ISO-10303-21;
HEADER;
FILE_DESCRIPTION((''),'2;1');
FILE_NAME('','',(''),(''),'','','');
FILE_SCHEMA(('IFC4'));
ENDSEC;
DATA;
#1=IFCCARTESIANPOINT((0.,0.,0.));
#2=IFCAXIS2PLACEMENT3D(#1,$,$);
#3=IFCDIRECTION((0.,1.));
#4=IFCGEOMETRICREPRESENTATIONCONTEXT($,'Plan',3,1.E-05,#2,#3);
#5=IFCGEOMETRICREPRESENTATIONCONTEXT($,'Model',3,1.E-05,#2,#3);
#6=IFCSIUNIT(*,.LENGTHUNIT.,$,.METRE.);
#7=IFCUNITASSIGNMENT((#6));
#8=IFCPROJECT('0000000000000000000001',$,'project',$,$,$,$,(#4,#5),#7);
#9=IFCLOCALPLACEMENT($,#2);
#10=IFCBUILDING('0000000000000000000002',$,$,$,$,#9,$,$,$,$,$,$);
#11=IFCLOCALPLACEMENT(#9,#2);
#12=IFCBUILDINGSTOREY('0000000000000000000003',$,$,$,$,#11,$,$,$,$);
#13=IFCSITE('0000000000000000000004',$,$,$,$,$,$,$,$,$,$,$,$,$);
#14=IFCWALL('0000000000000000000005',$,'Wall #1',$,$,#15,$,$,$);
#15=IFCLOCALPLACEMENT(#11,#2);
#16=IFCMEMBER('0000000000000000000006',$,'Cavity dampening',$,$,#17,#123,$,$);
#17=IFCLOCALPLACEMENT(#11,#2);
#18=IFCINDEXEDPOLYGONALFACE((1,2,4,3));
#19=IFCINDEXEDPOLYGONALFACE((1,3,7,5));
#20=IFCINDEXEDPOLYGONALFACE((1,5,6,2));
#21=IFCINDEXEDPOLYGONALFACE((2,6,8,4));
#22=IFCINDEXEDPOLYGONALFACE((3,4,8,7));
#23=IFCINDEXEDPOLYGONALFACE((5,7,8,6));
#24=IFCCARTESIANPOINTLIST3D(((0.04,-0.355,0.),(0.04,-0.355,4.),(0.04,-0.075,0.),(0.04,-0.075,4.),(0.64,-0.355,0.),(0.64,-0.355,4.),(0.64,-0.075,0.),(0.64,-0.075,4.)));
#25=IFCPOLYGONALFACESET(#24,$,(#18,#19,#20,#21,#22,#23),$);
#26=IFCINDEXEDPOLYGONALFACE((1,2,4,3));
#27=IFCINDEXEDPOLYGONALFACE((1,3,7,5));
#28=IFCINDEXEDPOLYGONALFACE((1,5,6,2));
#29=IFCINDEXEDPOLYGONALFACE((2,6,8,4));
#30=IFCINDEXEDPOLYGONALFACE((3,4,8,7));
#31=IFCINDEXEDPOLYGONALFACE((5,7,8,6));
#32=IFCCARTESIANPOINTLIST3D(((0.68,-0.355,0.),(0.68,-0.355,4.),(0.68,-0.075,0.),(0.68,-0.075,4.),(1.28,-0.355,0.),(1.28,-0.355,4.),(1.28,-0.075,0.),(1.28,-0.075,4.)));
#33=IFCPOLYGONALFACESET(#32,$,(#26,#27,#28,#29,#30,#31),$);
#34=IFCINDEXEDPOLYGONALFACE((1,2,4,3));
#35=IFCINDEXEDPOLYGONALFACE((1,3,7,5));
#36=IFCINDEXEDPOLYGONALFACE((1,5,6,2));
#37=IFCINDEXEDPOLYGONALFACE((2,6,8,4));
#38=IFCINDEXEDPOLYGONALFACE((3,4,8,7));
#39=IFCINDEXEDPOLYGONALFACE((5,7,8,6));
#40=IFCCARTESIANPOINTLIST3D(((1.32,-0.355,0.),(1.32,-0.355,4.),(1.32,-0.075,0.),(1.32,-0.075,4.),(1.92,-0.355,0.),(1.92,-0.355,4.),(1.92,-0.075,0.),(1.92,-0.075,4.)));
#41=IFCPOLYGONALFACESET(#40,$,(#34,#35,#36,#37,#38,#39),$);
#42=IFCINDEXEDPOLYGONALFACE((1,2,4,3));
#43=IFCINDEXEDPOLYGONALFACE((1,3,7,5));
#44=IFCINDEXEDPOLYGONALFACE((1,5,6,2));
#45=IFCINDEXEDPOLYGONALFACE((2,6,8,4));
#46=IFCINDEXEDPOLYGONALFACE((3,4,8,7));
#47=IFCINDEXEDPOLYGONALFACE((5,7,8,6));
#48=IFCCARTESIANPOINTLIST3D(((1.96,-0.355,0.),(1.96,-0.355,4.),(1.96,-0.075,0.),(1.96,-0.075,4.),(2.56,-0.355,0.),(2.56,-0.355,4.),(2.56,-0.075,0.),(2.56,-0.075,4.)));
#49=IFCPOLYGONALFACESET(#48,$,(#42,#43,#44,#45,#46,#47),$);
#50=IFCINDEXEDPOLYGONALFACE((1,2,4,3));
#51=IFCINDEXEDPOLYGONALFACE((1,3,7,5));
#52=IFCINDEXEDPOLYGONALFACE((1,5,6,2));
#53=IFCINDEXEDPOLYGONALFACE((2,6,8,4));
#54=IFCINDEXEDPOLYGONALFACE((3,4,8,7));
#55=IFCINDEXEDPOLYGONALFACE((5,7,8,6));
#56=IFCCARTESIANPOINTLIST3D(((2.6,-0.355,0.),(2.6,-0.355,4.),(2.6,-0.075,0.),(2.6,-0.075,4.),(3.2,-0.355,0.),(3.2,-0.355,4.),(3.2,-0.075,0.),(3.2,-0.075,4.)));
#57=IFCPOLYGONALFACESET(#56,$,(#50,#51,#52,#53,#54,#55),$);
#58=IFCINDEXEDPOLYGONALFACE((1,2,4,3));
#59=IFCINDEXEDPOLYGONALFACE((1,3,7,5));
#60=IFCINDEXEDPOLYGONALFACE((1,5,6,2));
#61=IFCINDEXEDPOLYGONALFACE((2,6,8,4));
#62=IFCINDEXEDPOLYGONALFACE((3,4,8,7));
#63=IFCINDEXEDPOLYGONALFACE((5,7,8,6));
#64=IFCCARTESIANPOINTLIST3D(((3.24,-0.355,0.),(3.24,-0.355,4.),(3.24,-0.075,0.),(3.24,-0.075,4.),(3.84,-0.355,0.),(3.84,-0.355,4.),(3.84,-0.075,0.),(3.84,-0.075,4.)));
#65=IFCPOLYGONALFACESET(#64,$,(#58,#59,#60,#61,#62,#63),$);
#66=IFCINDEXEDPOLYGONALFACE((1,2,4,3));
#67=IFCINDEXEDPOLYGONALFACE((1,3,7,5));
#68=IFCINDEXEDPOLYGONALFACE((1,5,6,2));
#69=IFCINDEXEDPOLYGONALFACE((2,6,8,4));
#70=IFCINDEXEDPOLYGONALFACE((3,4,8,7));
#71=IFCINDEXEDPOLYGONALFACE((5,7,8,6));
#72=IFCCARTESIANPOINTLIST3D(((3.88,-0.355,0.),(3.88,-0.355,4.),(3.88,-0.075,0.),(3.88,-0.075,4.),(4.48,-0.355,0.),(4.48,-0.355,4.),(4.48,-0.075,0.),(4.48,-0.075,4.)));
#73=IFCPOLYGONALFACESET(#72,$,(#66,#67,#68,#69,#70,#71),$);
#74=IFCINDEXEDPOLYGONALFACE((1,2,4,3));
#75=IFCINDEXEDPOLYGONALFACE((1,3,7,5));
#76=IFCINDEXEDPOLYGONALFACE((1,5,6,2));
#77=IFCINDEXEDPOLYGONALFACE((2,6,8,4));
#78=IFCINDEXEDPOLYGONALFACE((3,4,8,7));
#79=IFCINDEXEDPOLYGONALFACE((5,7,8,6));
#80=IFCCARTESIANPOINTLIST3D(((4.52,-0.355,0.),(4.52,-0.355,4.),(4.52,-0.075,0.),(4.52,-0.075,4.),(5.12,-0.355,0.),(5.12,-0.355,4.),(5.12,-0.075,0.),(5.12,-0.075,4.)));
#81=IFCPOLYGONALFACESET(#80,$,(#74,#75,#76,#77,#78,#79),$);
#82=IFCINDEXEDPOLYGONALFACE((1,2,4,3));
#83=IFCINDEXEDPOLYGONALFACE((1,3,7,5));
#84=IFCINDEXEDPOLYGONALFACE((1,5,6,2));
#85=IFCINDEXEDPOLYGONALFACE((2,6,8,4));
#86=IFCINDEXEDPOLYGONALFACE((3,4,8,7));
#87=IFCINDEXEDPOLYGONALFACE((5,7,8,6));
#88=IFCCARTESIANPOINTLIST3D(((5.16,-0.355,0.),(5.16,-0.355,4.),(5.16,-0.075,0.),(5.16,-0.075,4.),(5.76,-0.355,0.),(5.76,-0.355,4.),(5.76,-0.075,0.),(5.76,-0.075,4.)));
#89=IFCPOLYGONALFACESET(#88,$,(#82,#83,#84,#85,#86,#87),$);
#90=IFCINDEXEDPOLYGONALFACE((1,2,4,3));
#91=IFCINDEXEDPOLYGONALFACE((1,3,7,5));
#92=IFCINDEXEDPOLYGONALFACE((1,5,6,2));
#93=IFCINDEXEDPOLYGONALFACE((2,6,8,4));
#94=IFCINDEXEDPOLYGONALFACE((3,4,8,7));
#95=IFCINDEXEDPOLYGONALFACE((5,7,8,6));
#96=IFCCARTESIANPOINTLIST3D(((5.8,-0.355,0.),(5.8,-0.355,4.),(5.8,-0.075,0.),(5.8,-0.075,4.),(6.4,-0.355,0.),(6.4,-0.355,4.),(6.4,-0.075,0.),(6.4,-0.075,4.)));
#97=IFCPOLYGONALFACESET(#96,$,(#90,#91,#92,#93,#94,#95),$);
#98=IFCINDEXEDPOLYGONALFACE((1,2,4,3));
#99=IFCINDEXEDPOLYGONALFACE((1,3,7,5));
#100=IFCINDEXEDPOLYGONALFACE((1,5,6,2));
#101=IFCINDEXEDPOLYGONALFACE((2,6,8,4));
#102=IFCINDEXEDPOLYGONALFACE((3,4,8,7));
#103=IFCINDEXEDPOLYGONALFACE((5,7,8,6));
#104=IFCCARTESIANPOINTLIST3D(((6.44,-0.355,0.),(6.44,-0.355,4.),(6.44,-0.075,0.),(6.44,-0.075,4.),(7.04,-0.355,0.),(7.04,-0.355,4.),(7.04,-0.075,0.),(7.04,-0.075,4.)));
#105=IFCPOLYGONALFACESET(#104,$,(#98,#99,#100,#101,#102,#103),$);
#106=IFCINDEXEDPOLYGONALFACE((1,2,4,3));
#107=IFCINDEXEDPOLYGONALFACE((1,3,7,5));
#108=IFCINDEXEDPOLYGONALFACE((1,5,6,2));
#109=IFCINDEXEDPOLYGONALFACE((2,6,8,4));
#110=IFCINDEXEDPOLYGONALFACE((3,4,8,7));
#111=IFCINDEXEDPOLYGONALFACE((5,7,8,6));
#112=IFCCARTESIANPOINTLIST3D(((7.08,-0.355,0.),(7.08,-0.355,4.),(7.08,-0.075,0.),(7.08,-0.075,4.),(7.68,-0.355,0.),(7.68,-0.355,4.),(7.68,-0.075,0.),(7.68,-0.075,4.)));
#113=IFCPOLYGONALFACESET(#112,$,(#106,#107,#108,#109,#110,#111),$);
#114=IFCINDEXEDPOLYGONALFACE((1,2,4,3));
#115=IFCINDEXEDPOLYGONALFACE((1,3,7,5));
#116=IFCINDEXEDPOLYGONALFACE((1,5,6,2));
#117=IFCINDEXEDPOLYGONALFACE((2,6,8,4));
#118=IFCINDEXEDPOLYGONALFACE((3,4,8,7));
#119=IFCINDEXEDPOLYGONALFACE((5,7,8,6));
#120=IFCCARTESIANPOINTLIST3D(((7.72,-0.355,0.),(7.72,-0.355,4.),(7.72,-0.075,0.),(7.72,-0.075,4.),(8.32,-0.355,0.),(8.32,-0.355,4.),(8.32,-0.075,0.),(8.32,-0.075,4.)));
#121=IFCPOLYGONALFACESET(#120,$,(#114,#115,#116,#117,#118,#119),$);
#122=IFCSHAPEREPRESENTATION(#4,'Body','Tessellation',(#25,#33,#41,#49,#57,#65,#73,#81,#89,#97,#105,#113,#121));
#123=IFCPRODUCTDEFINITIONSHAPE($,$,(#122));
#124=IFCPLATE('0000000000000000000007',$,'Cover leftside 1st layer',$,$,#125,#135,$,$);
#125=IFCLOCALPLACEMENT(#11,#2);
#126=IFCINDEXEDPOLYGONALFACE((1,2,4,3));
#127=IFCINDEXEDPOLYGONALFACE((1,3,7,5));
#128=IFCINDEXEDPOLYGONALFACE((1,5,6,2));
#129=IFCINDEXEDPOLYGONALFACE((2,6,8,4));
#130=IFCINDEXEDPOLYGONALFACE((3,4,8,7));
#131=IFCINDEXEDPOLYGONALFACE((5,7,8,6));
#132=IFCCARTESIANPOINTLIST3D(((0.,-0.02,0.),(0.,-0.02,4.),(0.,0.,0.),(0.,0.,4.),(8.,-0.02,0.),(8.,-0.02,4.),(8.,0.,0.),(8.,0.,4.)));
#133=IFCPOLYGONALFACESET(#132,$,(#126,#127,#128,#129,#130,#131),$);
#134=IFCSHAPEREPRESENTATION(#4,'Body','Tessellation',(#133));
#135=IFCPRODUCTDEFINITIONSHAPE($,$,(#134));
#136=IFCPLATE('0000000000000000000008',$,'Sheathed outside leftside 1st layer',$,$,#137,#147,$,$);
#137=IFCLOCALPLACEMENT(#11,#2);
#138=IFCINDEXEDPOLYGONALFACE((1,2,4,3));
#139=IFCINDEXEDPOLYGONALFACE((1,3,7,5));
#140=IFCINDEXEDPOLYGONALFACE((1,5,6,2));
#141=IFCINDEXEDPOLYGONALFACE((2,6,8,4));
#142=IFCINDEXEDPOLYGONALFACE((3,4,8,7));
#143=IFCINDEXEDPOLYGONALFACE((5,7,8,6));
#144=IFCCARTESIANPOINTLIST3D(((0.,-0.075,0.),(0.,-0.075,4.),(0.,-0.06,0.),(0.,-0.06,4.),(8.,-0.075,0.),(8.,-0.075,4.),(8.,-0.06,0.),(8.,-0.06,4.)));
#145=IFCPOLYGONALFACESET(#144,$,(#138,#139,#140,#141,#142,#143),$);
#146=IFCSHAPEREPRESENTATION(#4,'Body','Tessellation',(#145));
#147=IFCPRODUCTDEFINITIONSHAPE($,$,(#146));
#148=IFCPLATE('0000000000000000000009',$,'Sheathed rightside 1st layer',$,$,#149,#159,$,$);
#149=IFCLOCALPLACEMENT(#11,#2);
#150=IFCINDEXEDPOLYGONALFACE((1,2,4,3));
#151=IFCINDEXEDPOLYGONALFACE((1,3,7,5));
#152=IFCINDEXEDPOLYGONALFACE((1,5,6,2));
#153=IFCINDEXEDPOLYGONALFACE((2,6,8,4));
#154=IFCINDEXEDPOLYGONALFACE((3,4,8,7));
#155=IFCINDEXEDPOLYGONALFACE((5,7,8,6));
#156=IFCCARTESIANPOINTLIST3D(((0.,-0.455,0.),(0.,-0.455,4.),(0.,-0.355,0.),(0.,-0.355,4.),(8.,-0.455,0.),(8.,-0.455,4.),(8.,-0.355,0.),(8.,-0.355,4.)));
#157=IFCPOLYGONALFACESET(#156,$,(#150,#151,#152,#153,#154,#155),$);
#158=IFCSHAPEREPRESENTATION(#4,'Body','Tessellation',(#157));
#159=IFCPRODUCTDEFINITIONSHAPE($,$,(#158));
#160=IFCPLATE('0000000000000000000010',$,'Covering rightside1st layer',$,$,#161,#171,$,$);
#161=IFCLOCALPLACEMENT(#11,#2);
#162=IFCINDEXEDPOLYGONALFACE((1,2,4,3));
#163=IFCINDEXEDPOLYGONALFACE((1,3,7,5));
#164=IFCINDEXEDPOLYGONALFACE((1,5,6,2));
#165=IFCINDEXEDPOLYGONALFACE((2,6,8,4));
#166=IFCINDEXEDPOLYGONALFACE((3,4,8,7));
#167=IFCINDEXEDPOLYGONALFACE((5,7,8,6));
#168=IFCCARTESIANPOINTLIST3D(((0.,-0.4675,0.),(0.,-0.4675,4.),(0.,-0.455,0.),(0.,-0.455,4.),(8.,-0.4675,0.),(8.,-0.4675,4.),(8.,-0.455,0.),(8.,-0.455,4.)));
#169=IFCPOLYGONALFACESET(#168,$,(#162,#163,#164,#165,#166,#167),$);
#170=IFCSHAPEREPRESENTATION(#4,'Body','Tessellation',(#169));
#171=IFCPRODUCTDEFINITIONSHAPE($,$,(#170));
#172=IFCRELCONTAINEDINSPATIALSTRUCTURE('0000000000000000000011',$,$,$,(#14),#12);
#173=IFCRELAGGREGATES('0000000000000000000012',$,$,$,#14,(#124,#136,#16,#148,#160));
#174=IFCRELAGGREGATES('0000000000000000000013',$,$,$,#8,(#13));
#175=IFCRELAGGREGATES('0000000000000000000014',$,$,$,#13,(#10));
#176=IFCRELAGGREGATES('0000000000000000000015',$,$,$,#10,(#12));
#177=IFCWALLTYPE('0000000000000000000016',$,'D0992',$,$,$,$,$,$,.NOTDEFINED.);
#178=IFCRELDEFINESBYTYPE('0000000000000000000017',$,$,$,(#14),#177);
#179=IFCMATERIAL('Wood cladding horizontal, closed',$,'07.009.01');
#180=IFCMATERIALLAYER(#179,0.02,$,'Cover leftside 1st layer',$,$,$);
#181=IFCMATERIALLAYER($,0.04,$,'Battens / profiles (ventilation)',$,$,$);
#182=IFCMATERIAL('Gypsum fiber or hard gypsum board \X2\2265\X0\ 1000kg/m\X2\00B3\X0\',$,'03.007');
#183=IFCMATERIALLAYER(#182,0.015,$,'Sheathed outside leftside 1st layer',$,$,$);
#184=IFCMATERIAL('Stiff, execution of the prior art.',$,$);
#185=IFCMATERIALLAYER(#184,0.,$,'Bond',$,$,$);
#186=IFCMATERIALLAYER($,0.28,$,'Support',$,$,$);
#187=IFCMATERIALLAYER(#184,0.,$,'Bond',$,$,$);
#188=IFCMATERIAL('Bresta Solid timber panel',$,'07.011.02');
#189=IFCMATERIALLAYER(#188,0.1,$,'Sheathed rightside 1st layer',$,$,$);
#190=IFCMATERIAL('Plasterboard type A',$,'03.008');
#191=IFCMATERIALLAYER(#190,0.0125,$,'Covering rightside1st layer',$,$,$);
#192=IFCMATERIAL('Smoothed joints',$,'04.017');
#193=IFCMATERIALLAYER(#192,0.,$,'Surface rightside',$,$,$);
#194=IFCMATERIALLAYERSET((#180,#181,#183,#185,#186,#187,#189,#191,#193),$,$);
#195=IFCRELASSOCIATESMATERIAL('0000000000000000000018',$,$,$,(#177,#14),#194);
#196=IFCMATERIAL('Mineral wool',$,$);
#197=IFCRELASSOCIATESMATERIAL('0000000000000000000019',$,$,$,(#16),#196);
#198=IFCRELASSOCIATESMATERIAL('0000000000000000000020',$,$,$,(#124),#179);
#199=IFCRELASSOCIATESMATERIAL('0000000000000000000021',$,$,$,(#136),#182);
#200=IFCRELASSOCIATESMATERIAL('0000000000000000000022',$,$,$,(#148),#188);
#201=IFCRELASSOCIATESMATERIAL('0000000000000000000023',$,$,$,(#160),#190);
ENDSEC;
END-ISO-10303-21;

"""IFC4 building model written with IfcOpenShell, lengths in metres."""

from ifc_helpers import new_model, si_unit, direction, frame, frame_2d, origin, origin_with_axes, place, context, project, spatial, rectangle, extrude, material, layer, layer_set, type_object, element, aggregate, save


model = new_model("IFC4")

# Units and contexts
plan_context = context("Plan", 3, precision=1e-05, world=origin(), true_north=direction((0.0, 1.0)))
model_context = context("Model", 3, precision=1e-05, world=origin(), true_north=direction((0.0, 1.0)))
ifc_project = project(units=[si_unit("LENGTHUNIT", "METRE")], contexts=[plan_context, model_context])

# Site, building, storey
site = spatial("IfcSite", under=ifc_project)
building_placement = place(None, origin())
building = spatial("IfcBuilding", under=site, at=building_placement)
storey_placement = place(building_placement, origin())
storey = spatial("IfcBuildingStorey", under=building, at=storey_placement)

# Wall, member, plates
ifc_material_1 = material(Name="Wood cladding horizontal, closed", Category="07.009.01")
ifc_layer_1 = layer(ifc_material_1, 0.02, Name="Cover leftside 1st layer")
ifc_layer_2 = layer(None, 0.04, Name="Battens / profiles (ventilation)")
ifc_material_2 = material(Name="Gypsum fiber or hard gypsum board ≥ 1000kg/m³", Category="03.007")
ifc_layer_3 = layer(ifc_material_2, 0.015, Name="Sheathed outside leftside 1st layer")
ifc_material_3 = material(Name="Stiff, execution of the prior art.")
ifc_layer_4 = layer(ifc_material_3, 0.0, Name="Bond")
ifc_layer_5 = layer(None, 0.28, Name="Support")
ifc_layer_6 = layer(ifc_material_3, 0.0, Name="Bond")
ifc_material_4 = material(Name="Bresta Solid timber panel", Category="07.011.02")
ifc_layer_7 = layer(ifc_material_4, 0.1, Name="Sheathed rightside 1st layer")
ifc_material_5 = material(Name="Plasterboard type A", Category="03.008")
ifc_layer_8 = layer(ifc_material_5, 0.0125, Name="Covering rightside1st layer")
ifc_material_6 = material(Name="Smoothed joints", Category="04.017")
ifc_layer_9 = layer(ifc_material_6, 0.0, Name="Surface rightside")
ifc_layer_set = layer_set([ifc_layer_1, ifc_layer_2, ifc_layer_3, ifc_layer_4, ifc_layer_5, ifc_layer_6, ifc_layer_7, ifc_layer_8, ifc_layer_9])
wall_type = type_object("IfcWallType", Name="D0992", PredefinedType="NOTDEFINED", material=ifc_layer_set)
wall_placement = place(None, frame((0.0, 0.0, 0.0), z_axis=(0.0, -1.0, 0.0), x_axis=(1.0, 0.0, 0.0)))
wall = element("IfcWall", 1, at=wall_placement, inside=storey, type_object=wall_type, material=ifc_layer_set, Name="Wall #1")
ifc_material_7 = material(Name="Mineral wool")
member_1_placement = place(wall_placement, origin())
member_1 = element("IfcMember", 2, at=member_1_placement, material=ifc_material_7, Name="Cavity dampening", context=plan_context, shape_type="SweptSolid", body=[
    extrude(rectangle(XDim=0.6, YDim=0.28, at=frame_2d((0.3, 0.14), x_axis=(1.0, 0.0))), frame((0.04, 4.0, 0.075), z_axis=(0.0, -1.0, 0.0), x_axis=(1.0, 0.0, 0.0)), (0.0, 0.0, 1.0), 4.0),
    extrude(rectangle(XDim=0.6, YDim=0.28, at=frame_2d((0.3, 0.14), x_axis=(1.0, 0.0))), frame((0.68, 4.0, 0.075), z_axis=(0.0, -1.0, 0.0), x_axis=(1.0, 0.0, 0.0)), (0.0, 0.0, 1.0), 4.0),
    extrude(rectangle(XDim=0.6, YDim=0.28, at=frame_2d((0.3, 0.14), x_axis=(1.0, 0.0))), frame((1.32, 4.0, 0.075), z_axis=(0.0, -1.0, 0.0), x_axis=(1.0, 0.0, 0.0)), (0.0, 0.0, 1.0), 4.0),
    extrude(rectangle(XDim=0.6, YDim=0.28, at=frame_2d((0.3, 0.14), x_axis=(1.0, 0.0))), frame((1.96, 4.0, 0.075), z_axis=(0.0, -1.0, 0.0), x_axis=(1.0, 0.0, 0.0)), (0.0, 0.0, 1.0), 4.0),
    extrude(rectangle(XDim=0.6, YDim=0.28, at=frame_2d((0.3, 0.14), x_axis=(1.0, 0.0))), frame((2.6, 4.0, 0.075), z_axis=(0.0, -1.0, 0.0), x_axis=(1.0, 0.0, 0.0)), (0.0, 0.0, 1.0), 4.0),
    extrude(rectangle(XDim=0.6, YDim=0.28, at=frame_2d((0.3, 0.14), x_axis=(1.0, 0.0))), frame((3.24, 4.0, 0.075), z_axis=(0.0, -1.0, 0.0), x_axis=(1.0, 0.0, 0.0)), (0.0, 0.0, 1.0), 4.0),
    extrude(rectangle(XDim=0.6, YDim=0.28, at=frame_2d((0.3, 0.14), x_axis=(1.0, 0.0))), frame((3.88, 4.0, 0.075), z_axis=(0.0, -1.0, 0.0), x_axis=(1.0, 0.0, 0.0)), (0.0, 0.0, 1.0), 4.0),
    extrude(rectangle(XDim=0.6, YDim=0.28, at=frame_2d((0.3, 0.14), x_axis=(1.0, 0.0))), frame((4.52, 4.0, 0.075), z_axis=(0.0, -1.0, 0.0), x_axis=(1.0, 0.0, 0.0)), (0.0, 0.0, 1.0), 4.0),
    extrude(rectangle(XDim=0.6, YDim=0.28, at=frame_2d((0.3, 0.14), x_axis=(1.0, 0.0))), frame((5.16, 4.0, 0.075), z_axis=(0.0, -1.0, 0.0), x_axis=(1.0, 0.0, 0.0)), (0.0, 0.0, 1.0), 4.0),
    extrude(rectangle(XDim=0.6, YDim=0.28, at=frame_2d((0.3, 0.14), x_axis=(1.0, 0.0))), frame((5.8, 4.0, 0.075), z_axis=(0.0, -1.0, 0.0), x_axis=(1.0, 0.0, 0.0)), (0.0, 0.0, 1.0), 4.0),
    extrude(rectangle(XDim=0.6, YDim=0.28, at=frame_2d((0.3, 0.14), x_axis=(1.0, 0.0))), frame((6.44, 4.0, 0.075), z_axis=(0.0, -1.0, 0.0), x_axis=(1.0, 0.0, 0.0)), (0.0, 0.0, 1.0), 4.0),
    extrude(rectangle(XDim=0.6, YDim=0.28, at=frame_2d((0.3, 0.14), x_axis=(1.0, 0.0))), frame((7.08, 4.0, 0.075), z_axis=(0.0, -1.0, 0.0), x_axis=(1.0, 0.0, 0.0)), (0.0, 0.0, 1.0), 4.0),
    extrude(rectangle(XDim=0.6, YDim=0.28, at=frame_2d((0.3, 0.14), x_axis=(1.0, 0.0))), frame((7.72, 4.0, 0.075), z_axis=(0.0, -1.0, 0.0), x_axis=(1.0, 0.0, 0.0)), (0.0, 0.0, 1.0), 4.0),
])
plate_1_placement = place(wall_placement, origin())
plate_1 = element("IfcPlate", 3, at=plate_1_placement, material=ifc_material_1, Name="Cover leftside 1st layer", context=plan_context, shape_type="SweptSolid", body=[
    extrude(rectangle(XDim=8.0, YDim=4.0, at=frame_2d((4.0, 2.0), x_axis=(1.0, 0.0))), origin_with_axes(), (0.0, 0.0, 1.0), 0.02),
])
plate_2_placement = place(wall_placement, origin())
plate_2 = element("IfcPlate", 4, at=plate_2_placement, material=ifc_material_2, Name="Sheathed outside leftside 1st layer", context=plan_context, shape_type="SweptSolid", body=[
    extrude(rectangle(XDim=8.0, YDim=4.0, at=frame_2d((4.0, 2.0), x_axis=(1.0, 0.0))), frame((0.0, 0.0, 0.06), z_axis=(0.0, 0.0, 1.0), x_axis=(1.0, 0.0, 0.0)), (0.0, 0.0, 1.0), 0.015),
])
plate_3_placement = place(wall_placement, origin())
plate_3 = element("IfcPlate", 5, at=plate_3_placement, material=ifc_material_4, Name="Sheathed rightside 1st layer", context=plan_context, shape_type="SweptSolid", body=[
    extrude(rectangle(XDim=8.0, YDim=4.0, at=frame_2d((4.0, 2.0), x_axis=(1.0, 0.0))), frame((0.0, 0.0, 0.355), z_axis=(0.0, 0.0, 1.0), x_axis=(1.0, 0.0, 0.0)), (0.0, 0.0, 1.0), 0.1),
])
plate_4_placement = place(wall_placement, origin())
plate_4 = element("IfcPlate", 6, at=plate_4_placement, material=ifc_material_5, Name="Covering rightside1st layer", context=plan_context, shape_type="SweptSolid", body=[
    extrude(rectangle(XDim=8.0, YDim=4.0, at=frame_2d((4.0, 2.0), x_axis=(1.0, 0.0))), frame((0.0, 0.0, 0.455), z_axis=(0.0, 0.0, 1.0), x_axis=(1.0, 0.0, 0.0)), (0.0, 0.0, 1.0), 0.0125),
])
aggregate(wall, [plate_1, plate_2, member_1, plate_3, plate_4])

save(model, "model.ifc")
